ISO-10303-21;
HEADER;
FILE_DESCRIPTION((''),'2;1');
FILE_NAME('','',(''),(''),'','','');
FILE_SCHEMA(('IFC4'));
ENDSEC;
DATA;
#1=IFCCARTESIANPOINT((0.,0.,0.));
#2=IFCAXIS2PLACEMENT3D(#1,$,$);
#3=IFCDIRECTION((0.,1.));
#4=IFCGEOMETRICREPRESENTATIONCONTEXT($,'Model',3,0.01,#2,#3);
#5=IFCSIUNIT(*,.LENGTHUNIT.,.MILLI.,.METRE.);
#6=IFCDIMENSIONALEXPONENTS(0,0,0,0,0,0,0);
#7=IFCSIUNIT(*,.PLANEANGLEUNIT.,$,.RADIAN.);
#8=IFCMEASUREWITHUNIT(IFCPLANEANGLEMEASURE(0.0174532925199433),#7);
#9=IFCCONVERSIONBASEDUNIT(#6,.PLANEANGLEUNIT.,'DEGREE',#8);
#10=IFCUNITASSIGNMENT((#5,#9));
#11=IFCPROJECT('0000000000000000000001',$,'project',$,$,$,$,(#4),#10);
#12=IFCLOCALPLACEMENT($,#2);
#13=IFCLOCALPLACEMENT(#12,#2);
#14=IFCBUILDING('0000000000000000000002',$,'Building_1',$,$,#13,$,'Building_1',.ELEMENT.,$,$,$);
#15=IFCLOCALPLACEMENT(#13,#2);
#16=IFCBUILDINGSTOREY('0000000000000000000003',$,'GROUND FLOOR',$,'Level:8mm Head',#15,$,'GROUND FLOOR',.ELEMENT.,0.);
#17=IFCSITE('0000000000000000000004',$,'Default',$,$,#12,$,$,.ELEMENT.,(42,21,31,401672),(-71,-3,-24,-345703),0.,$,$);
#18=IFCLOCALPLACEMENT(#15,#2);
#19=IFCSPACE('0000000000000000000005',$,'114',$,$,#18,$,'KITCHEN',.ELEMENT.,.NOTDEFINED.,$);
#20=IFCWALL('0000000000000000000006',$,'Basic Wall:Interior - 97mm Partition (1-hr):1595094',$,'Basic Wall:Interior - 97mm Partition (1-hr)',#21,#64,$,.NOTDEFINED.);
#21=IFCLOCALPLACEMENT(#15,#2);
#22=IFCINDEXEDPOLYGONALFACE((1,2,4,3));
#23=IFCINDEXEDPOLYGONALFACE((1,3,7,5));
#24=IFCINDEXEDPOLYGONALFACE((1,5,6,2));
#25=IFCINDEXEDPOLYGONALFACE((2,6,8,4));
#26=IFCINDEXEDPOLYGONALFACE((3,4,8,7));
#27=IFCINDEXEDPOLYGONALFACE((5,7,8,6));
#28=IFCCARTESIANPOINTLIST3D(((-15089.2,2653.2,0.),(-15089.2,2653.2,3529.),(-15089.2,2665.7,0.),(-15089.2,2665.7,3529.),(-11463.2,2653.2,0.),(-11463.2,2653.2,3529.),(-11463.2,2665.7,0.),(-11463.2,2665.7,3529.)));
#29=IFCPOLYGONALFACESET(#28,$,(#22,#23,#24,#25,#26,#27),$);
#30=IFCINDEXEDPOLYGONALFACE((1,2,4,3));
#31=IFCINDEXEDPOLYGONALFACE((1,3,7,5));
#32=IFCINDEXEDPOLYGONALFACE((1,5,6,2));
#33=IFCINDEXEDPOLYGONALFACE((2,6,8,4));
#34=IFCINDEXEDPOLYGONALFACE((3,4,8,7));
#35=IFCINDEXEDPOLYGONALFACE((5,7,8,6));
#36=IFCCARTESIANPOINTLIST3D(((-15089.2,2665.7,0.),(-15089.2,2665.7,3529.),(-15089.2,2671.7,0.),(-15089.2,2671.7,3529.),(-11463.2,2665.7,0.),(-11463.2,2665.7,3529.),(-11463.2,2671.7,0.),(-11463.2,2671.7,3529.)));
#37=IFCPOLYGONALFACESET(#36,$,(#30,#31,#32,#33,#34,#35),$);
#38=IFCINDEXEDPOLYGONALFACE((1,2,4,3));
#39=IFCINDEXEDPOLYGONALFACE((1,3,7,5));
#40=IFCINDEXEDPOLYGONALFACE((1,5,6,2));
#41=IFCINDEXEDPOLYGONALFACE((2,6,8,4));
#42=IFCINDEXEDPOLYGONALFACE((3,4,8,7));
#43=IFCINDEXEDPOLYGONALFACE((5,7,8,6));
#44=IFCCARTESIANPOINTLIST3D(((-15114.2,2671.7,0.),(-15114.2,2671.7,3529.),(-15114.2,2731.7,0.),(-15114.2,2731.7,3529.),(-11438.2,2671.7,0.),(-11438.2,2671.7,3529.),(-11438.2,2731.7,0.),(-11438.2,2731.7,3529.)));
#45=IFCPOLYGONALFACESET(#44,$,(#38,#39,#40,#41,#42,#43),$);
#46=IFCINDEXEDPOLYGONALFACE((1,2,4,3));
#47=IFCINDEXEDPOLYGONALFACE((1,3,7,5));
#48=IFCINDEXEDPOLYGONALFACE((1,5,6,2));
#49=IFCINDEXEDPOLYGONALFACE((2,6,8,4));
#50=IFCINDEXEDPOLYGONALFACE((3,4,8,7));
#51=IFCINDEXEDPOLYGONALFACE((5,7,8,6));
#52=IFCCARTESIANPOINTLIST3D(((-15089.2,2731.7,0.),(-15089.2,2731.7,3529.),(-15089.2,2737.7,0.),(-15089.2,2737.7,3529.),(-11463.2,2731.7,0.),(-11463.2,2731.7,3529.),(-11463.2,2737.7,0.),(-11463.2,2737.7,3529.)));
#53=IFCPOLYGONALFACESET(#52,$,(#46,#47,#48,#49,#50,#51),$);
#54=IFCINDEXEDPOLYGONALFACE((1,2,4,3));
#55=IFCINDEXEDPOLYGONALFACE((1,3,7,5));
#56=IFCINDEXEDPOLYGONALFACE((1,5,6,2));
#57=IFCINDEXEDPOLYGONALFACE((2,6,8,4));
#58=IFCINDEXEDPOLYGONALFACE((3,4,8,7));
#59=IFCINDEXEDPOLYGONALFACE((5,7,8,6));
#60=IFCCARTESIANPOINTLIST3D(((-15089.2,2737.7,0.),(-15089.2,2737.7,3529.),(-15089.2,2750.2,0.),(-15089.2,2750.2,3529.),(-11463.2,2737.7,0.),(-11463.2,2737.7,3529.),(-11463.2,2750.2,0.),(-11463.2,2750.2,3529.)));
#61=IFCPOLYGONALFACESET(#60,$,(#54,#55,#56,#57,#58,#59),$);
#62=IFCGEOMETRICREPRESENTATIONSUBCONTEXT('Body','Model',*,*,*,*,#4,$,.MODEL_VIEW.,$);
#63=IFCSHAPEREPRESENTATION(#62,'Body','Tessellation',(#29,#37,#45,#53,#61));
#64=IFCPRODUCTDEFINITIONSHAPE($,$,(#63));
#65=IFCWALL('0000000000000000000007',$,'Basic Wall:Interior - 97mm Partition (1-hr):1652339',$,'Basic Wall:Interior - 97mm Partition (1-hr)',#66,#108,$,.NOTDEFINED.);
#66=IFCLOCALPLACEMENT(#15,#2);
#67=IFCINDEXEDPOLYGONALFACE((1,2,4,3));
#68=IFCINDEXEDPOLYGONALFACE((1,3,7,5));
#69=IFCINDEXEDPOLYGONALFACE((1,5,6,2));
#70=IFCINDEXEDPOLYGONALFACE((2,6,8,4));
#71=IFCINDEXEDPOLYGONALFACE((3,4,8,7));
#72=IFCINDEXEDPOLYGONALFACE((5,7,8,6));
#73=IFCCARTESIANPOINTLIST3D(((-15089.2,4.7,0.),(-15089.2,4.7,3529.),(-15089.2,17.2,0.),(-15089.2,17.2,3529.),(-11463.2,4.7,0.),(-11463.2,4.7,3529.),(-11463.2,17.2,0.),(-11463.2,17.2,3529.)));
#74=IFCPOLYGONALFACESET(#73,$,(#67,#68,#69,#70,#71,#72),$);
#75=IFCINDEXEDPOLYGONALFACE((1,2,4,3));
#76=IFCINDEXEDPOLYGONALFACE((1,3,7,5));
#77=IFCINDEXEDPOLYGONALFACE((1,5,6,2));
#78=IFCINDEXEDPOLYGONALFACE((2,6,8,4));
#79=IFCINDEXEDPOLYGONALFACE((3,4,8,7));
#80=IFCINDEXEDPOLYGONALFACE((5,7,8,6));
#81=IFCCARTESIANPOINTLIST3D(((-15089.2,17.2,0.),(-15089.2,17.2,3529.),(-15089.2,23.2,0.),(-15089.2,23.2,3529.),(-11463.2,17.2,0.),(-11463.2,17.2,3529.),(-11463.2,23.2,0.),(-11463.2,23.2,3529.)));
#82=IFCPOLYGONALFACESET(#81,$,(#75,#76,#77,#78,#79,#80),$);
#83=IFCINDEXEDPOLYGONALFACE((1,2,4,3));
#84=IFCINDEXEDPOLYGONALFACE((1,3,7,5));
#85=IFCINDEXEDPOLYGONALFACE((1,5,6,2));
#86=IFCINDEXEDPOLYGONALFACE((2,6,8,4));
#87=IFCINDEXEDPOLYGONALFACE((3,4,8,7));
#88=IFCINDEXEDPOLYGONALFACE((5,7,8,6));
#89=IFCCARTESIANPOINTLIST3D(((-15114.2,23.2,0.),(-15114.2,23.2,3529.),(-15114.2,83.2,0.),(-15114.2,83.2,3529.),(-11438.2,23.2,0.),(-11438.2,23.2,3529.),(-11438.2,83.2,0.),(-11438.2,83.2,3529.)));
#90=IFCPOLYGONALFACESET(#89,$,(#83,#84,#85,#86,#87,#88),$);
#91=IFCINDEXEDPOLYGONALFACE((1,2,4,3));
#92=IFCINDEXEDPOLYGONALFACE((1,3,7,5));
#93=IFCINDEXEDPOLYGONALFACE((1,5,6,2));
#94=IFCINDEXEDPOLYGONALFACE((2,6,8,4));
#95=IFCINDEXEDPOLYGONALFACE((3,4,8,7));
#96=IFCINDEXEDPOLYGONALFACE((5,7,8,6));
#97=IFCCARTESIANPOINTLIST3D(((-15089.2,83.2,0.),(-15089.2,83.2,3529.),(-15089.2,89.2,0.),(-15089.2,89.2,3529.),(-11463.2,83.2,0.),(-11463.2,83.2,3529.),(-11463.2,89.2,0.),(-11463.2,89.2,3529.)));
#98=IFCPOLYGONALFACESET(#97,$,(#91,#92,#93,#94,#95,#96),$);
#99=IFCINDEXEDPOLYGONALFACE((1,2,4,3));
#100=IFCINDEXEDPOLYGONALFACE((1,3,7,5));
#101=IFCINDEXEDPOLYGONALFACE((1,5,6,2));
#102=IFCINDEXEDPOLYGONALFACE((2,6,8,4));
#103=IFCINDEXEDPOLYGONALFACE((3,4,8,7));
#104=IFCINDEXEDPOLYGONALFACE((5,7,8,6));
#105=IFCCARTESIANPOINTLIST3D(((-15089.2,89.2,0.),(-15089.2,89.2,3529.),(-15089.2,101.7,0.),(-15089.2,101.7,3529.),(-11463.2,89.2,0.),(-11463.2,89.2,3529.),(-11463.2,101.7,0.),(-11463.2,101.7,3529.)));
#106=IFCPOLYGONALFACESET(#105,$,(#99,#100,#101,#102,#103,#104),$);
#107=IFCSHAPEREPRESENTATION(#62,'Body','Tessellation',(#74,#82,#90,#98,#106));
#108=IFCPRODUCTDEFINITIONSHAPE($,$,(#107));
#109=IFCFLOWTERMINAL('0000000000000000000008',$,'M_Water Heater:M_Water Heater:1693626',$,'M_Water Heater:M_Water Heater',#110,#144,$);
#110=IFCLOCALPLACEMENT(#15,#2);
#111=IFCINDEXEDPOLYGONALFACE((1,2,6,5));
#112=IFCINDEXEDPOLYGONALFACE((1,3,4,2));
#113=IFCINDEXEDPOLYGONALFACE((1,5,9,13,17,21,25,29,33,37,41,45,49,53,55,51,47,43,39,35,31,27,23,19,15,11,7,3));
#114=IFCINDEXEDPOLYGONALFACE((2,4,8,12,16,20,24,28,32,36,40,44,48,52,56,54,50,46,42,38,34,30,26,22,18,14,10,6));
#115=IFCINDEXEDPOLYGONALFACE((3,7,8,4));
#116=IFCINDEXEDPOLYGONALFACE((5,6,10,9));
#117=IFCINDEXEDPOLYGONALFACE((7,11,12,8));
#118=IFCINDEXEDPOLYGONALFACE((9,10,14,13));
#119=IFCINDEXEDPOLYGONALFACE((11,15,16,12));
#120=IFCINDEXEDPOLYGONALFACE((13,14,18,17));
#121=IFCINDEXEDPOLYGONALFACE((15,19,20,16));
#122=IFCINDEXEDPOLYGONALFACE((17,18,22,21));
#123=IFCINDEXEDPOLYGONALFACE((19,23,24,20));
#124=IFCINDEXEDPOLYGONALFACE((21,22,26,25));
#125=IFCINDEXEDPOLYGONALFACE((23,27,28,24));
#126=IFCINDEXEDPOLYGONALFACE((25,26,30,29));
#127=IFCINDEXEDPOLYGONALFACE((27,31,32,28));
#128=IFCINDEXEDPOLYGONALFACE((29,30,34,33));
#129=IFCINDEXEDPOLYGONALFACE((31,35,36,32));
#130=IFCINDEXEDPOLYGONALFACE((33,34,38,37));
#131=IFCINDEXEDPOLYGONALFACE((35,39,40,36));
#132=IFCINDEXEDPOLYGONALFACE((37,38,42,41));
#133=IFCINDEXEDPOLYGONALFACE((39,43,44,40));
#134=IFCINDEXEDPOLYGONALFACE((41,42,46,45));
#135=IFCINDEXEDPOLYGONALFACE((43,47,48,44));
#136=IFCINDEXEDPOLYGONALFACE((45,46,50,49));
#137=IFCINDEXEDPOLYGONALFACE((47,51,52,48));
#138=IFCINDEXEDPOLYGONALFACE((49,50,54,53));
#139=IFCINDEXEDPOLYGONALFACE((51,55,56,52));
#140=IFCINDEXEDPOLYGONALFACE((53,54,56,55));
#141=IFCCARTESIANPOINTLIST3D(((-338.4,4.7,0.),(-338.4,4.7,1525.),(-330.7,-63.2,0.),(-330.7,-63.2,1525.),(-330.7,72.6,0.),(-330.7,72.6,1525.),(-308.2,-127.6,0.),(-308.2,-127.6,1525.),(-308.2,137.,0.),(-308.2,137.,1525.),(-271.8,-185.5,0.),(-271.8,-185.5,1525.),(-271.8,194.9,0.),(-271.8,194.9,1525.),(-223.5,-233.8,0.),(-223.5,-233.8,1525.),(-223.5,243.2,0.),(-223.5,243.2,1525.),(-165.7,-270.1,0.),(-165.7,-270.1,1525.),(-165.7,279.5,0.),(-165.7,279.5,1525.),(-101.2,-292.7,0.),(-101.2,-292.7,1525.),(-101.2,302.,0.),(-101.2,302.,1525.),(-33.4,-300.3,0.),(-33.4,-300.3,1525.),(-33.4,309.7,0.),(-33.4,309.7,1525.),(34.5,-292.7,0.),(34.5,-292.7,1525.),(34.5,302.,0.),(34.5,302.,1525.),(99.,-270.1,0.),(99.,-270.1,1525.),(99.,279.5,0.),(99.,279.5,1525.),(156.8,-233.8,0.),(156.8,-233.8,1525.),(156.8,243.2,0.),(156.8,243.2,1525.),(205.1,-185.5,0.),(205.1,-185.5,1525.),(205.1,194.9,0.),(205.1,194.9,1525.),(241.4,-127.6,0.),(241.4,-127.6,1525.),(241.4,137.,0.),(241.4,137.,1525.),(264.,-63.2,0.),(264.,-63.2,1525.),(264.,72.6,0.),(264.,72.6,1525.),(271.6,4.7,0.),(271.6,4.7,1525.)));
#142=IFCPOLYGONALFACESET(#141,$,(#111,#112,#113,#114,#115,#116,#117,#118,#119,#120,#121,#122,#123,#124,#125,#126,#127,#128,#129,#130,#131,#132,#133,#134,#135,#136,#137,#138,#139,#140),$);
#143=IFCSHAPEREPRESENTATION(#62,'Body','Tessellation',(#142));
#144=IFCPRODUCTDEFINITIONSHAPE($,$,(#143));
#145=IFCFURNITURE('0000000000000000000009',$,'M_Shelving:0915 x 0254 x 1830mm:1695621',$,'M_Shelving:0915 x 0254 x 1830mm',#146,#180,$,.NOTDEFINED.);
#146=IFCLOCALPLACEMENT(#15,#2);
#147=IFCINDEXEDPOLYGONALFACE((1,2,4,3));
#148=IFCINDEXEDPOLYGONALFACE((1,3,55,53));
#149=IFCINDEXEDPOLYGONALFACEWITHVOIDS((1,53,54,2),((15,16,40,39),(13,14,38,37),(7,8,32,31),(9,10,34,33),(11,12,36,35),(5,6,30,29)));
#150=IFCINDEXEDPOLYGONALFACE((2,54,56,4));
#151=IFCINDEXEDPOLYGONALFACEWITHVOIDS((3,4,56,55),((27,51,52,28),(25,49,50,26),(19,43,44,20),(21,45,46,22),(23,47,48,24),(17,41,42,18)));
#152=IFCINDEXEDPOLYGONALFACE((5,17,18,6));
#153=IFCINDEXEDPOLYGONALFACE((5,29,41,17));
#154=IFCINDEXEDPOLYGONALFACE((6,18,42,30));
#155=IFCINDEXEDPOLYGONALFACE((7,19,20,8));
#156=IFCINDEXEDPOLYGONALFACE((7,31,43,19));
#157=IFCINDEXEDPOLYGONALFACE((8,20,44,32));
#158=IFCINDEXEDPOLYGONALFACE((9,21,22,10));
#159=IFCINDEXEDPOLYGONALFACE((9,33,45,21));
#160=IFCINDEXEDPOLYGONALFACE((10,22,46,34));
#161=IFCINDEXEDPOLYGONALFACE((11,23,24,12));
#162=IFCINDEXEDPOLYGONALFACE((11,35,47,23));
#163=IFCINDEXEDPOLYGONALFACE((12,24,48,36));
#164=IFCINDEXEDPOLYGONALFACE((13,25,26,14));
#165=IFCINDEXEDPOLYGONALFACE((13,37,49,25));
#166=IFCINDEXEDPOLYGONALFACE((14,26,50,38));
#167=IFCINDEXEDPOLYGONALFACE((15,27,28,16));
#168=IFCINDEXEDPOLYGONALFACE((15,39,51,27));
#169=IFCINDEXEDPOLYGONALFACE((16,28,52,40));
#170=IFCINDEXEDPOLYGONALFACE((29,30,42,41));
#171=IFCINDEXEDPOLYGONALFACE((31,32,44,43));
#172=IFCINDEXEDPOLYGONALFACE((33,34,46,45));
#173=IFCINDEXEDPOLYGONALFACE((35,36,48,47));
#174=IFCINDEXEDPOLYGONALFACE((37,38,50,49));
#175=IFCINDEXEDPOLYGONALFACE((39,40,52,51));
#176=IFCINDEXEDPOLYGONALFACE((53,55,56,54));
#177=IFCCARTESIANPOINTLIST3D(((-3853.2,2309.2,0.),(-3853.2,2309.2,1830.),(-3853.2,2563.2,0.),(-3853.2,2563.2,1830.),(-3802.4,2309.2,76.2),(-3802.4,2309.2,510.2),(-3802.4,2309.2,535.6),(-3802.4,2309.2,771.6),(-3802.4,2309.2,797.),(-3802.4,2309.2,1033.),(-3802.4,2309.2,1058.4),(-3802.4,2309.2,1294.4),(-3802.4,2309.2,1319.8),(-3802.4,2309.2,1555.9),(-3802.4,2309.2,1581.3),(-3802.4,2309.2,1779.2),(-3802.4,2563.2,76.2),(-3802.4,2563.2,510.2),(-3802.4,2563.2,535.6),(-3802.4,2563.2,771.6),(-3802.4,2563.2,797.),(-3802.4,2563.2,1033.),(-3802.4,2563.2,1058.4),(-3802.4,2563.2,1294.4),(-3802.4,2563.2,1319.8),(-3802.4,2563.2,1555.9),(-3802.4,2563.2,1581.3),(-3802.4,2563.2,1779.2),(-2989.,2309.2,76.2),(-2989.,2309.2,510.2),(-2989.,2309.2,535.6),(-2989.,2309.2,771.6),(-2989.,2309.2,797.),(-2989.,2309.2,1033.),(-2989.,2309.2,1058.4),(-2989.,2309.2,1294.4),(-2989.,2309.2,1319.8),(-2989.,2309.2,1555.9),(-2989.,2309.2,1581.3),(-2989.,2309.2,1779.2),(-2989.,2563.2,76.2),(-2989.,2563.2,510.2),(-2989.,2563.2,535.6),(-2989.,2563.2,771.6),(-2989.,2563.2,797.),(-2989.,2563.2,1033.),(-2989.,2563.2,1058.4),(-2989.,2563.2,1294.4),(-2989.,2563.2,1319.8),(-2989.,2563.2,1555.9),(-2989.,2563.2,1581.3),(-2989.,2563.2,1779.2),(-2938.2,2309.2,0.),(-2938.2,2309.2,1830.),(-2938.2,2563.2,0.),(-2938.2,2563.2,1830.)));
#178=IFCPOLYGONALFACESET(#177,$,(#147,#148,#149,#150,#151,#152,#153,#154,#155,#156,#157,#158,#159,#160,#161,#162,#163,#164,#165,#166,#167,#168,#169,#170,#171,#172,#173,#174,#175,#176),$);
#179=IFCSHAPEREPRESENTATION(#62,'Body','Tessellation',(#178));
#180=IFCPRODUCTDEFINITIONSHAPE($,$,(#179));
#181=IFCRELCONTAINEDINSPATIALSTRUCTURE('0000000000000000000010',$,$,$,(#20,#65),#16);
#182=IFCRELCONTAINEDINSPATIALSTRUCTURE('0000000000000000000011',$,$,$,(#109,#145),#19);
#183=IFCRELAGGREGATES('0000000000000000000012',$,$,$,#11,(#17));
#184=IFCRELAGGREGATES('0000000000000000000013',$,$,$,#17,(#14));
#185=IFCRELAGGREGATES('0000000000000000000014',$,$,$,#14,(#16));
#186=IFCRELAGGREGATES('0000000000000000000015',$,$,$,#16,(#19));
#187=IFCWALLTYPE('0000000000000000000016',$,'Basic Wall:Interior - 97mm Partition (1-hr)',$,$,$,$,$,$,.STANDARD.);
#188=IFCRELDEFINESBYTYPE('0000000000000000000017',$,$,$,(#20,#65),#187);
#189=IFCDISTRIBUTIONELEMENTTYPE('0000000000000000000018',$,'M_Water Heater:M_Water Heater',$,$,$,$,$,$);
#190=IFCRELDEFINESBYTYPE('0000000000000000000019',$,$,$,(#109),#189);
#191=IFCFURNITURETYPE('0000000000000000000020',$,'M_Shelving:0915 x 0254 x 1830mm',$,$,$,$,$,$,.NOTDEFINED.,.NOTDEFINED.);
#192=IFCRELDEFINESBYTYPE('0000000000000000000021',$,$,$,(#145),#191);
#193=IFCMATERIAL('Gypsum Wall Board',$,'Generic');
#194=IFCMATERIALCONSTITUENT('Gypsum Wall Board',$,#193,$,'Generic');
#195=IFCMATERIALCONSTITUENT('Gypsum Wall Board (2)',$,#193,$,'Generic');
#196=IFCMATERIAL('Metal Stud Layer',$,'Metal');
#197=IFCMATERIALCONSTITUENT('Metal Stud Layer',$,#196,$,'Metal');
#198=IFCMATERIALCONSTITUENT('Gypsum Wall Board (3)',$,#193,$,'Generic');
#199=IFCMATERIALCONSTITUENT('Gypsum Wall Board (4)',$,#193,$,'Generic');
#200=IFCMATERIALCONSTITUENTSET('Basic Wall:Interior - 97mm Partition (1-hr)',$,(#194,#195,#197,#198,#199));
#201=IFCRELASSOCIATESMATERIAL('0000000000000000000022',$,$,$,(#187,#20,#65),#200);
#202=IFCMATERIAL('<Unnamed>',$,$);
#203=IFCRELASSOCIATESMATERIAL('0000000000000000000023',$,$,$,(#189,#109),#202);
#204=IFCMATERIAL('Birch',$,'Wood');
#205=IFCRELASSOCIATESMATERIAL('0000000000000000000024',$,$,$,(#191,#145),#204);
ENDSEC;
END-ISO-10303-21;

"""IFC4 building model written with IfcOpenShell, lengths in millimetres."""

from ifc_helpers import new_model, entity, si_unit, converted_unit, direction, frame, origin, place, context, subcontext, project, spatial, arc, indexed_curve, outline, extrude, source, transform, mapped, material, constituent, constituent_set, type_object, type_shapes, element, save


model = new_model("IFC4")

# Units and contexts
model_context = context("Model", 3, precision=0.01, world=origin(), true_north=direction((0.0, 1.0)))
body_context = subcontext(model_context, "Body", "Model", "MODEL_VIEW")
ifc_project = project(units=[si_unit("LENGTHUNIT", "METRE", prefix="MILLI"), converted_unit("PLANEANGLEUNIT", "DEGREE", entity("IfcPlaneAngleMeasure", 0.0174532925199433), si_unit("PLANEANGLEUNIT", "RADIAN"), dimensions=[0, 0, 0, 0, 0, 0, 0])], contexts=[model_context])

# Site, building, storey
site_placement = place(None, origin())
site = spatial("IfcSite", under=ifc_project, at=site_placement, Name="Default", CompositionType="ELEMENT", RefLatitude=(42, 21, 31, 401672), RefLongitude=(-71, -3, -24, -345703), RefElevation=0.0)
building_placement = place(site_placement, origin())
building = spatial("IfcBuilding", under=site, at=building_placement, Name="Building_1", LongName="Building_1", CompositionType="ELEMENT")
storey_placement = place(building_placement, origin())
storey = spatial("IfcBuildingStorey", under=building, at=storey_placement, Name="GROUND FLOOR", ObjectType="Level:8mm Head", LongName="GROUND FLOOR", CompositionType="ELEMENT", Elevation=0.0)

# Walls
ifc_material_1 = material(Name="Gypsum Wall Board", Category="Generic")
ifc_constituent_1 = constituent(ifc_material_1, Name="Gypsum Wall Board", Category="Generic")
ifc_constituent_2 = constituent(ifc_material_1, Name="Gypsum Wall Board (2)", Category="Generic")
ifc_material_2 = material(Name="Metal Stud Layer", Category="Metal")
ifc_constituent_3 = constituent(ifc_material_2, Name="Metal Stud Layer", Category="Metal")
ifc_constituent_4 = constituent(ifc_material_1, Name="Gypsum Wall Board (3)", Category="Generic")
ifc_constituent_5 = constituent(ifc_material_1, Name="Gypsum Wall Board (4)", Category="Generic")
ifc_constituent_set_1 = constituent_set(constituents=[ifc_constituent_1, ifc_constituent_2, ifc_constituent_3, ifc_constituent_4, ifc_constituent_5], Name="Basic Wall:Interior - 97mm Partition (1-hr)")
wall_type_1 = type_object("IfcWallType", Name="Basic Wall:Interior - 97mm Partition (1-hr)", PredefinedType="STANDARD", material=ifc_constituent_set_1)
wall_1_placement = place(storey_placement, frame((-15089.2, 2701.7, 0.0)))
element("IfcWall", 1, at=wall_1_placement, inside=storey, type_object=wall_type_1, material=ifc_constituent_set_1, Name="Basic Wall:Interior - 97mm Partition (1-hr):1595094", ObjectType="Basic Wall:Interior - 97mm Partition (1-hr)", PredefinedType="NOTDEFINED", context=body_context, shape_type="SweptSolid", body=[
    extrude(outline(indexed_curve([(-6.3, -1813.0), (6.2, -1813.0), (6.3, 1813.0), (-6.2, 1813.0), (-6.3, -1813.0)], self_intersect=False)), frame((1813.0, -42.3, 0.0), z_axis=(0.0, 0.0, 1.0), x_axis=(0.0, 1.0, 0.0)), (0.0, 0.0, 1.0), 3529.0),
    extrude(outline(indexed_curve([(-1813.0, -3.0), (1813.0, -3.0), (1813.0, 3.0), (-1813.0, 3.0), (-1813.0, -3.0)], self_intersect=False)), frame((1813.0, -33.0, 0.0)), (0.0, 0.0, 1.0), 3529.0),
    extrude(outline(indexed_curve([(-1838.0, -30.0), (1838.0, -30.0), (1838.0, 30.0), (-1838.0, 30.0), (-1838.0, -30.0)], self_intersect=False)), frame((1813.0, 0.0, 0.0)), (0.0, 0.0, 1.0), 3529.0),
    extrude(outline(indexed_curve([(-1813.0, -3.0), (1813.0, -3.0), (1813.0, 3.0), (-1813.0, 3.0), (-1813.0, -3.0)], self_intersect=False)), frame((1813.0, 33.0, 0.0)), (0.0, 0.0, 1.0), 3529.0),
    extrude(outline(indexed_curve([(-6.3, -1813.0), (6.2, -1813.0), (6.3, 1813.0), (-6.2, 1813.0), (-6.3, -1813.0)], self_intersect=False)), frame((1813.0, 42.2, 0.0), z_axis=(0.0, 0.0, 1.0), x_axis=(0.0, -1.0, 0.0)), (0.0, 0.0, 1.0), 3529.0),
])
wall_2_placement = place(storey_placement, frame((-15089.2, 53.2, 0.0)))
element("IfcWall", 2, at=wall_2_placement, inside=storey, type_object=wall_type_1, material=ifc_constituent_set_1, Name="Basic Wall:Interior - 97mm Partition (1-hr):1652339", ObjectType="Basic Wall:Interior - 97mm Partition (1-hr)", PredefinedType="NOTDEFINED", context=body_context, shape_type="SweptSolid", body=[
    extrude(outline(indexed_curve([(-6.3, -1813.0), (6.2, -1813.0), (6.3, 1813.0), (-6.2, 1813.0), (-6.3, -1813.0)], self_intersect=False)), frame((1813.0, -42.2, 0.0), z_axis=(0.0, 0.0, 1.0), x_axis=(0.0, 1.0, 0.0)), (0.0, 0.0, 1.0), 3529.0),
    extrude(outline(indexed_curve([(-1813.0, -3.0), (1813.0, -3.0), (1813.0, 3.0), (-1813.0, 3.0), (-1813.0, -3.0)], self_intersect=False)), frame((1813.0, -33.0, 0.0)), (0.0, 0.0, 1.0), 3529.0),
    extrude(outline(indexed_curve([(-1838.0, -30.0), (1838.0, -30.0), (1838.0, 30.0), (-1838.0, 30.0), (-1838.0, -30.0)], self_intersect=False)), frame((1813.0, 0.0, 0.0)), (0.0, 0.0, 1.0), 3529.0),
    extrude(outline(indexed_curve([(-1813.0, -3.0), (1813.0, -3.0), (1813.0, 3.0), (-1813.0, 3.0), (-1813.0, -3.0)], self_intersect=False)), frame((1813.0, 33.0, 0.0)), (0.0, 0.0, 1.0), 3529.0),
    extrude(outline(indexed_curve([(-6.3, -1813.0), (6.2, -1813.0), (6.3, 1813.0), (-6.2, 1813.0), (-6.3, -1813.0)], self_intersect=False)), frame((1813.0, 42.2, 0.0), z_axis=(0.0, 0.0, 1.0), x_axis=(0.0, -1.0, 0.0)), (0.0, 0.0, 1.0), 3529.0),
])

# Shared definitions
space_1_placement = place(storey_placement, origin())
space_1 = spatial("IfcSpace", under=storey, at=space_1_placement, Name="114", LongName="KITCHEN", CompositionType="ELEMENT", PredefinedType="NOTDEFINED")

# Flow terminal
ifc_material_3 = material(Name="<Unnamed>")
distribution_element_type = type_object("IfcDistributionElementType", Name="M_Water Heater:M_Water Heater", material=ifc_material_3)
shared_shape_1 = source(origin(), body_context, "Body", "SweptSolid", [
    extrude(outline(indexed_curve([(-305.0, 0.0), (0.0, -305.0), (305.0, 0.0), (0.0, 305.0)], segments=[arc(1, 2, 3), arc(3, 4, 1)], self_intersect=False)), origin(), (0.0, 0.0, 1.0), 1525.0),
])
type_shapes(distribution_element_type, [shared_shape_1])
flow_terminal_placement = place(space_1_placement, frame((-33.4, 4.7, 0.0)))
element("IfcFlowTerminal", 3, at=flow_terminal_placement, inside=space_1, type_object=distribution_element_type, material=ifc_material_3, Name="M_Water Heater:M_Water Heater:1693626", ObjectType="M_Water Heater:M_Water Heater", context=body_context, shape_type="MappedRepresentation", body=[
    mapped(shared_shape_1, transform((0.0, 0.0, 0.0), scale=1.0)),
])

# Furniture
ifc_material_4 = material(Name="Birch", Category="Wood")
furniture_type_1 = type_object("IfcFurnitureType", Name="M_Shelving:0915 x 0254 x 1830mm", AssemblyPlace="NOTDEFINED", PredefinedType="NOTDEFINED", material=ifc_material_4)
shared_shape_2 = source(origin(), body_context, "Body", "SweptSolid", [
    extrude(outline(indexed_curve([(-457.5, -915.0), (457.5, -915.0), (457.5, 915.0), (-457.5, 915.0), (-457.5, -915.0)], self_intersect=False), holes=[indexed_curve([(-406.7, 864.2), (406.7, 864.2), (406.7, 666.3), (-406.7, 666.3), (-406.7, 864.2)], self_intersect=False), indexed_curve([(-406.7, -838.8), (-406.7, -404.8), (406.7, -404.8), (406.7, -838.8), (-406.7, -838.8)], self_intersect=False), indexed_curve([(406.7, 143.4), (-406.7, 143.4), (-406.7, 379.4), (406.7, 379.4), (406.7, 143.4)], self_intersect=False), indexed_curve([(-406.7, 640.9), (406.7, 640.9), (406.7, 404.8), (-406.7, 404.8), (-406.7, 640.9)], self_intersect=False), indexed_curve([(-406.7, 118.0), (406.7, 118.0), (406.7, -118.0), (-406.7, -118.0), (-406.7, 118.0)], self_intersect=False), indexed_curve([(-406.7, -143.4), (406.7, -143.4), (406.7, -379.4), (-406.7, -379.4), (-406.7, -143.4)], self_intersect=False)]), frame((0.0, -431.8, 915.0), z_axis=(0.0, 1.0, 0.0), x_axis=(-1.0, 0.0, 0.0)), (0.0, 0.0, 1.0), 254.0),
])
type_shapes(furniture_type_1, [shared_shape_2])
for number, where, name in (
    (4, (-3395.7, 2741.0, 0.0), "M_Shelving:0915 x 0254 x 1830mm:1695621"),
):
    element("IfcFurniture", number, at=place(space_1_placement, frame(where)), inside=space_1, type_object=furniture_type_1, material=ifc_material_4, Name=name, ObjectType="M_Shelving:0915 x 0254 x 1830mm", PredefinedType="NOTDEFINED", context=body_context, shape_type="MappedRepresentation", body=[
        mapped(shared_shape_2, transform((0.0, 0.0, 0.0), scale=1.0)),
    ])

save(model, "model.ifc")
